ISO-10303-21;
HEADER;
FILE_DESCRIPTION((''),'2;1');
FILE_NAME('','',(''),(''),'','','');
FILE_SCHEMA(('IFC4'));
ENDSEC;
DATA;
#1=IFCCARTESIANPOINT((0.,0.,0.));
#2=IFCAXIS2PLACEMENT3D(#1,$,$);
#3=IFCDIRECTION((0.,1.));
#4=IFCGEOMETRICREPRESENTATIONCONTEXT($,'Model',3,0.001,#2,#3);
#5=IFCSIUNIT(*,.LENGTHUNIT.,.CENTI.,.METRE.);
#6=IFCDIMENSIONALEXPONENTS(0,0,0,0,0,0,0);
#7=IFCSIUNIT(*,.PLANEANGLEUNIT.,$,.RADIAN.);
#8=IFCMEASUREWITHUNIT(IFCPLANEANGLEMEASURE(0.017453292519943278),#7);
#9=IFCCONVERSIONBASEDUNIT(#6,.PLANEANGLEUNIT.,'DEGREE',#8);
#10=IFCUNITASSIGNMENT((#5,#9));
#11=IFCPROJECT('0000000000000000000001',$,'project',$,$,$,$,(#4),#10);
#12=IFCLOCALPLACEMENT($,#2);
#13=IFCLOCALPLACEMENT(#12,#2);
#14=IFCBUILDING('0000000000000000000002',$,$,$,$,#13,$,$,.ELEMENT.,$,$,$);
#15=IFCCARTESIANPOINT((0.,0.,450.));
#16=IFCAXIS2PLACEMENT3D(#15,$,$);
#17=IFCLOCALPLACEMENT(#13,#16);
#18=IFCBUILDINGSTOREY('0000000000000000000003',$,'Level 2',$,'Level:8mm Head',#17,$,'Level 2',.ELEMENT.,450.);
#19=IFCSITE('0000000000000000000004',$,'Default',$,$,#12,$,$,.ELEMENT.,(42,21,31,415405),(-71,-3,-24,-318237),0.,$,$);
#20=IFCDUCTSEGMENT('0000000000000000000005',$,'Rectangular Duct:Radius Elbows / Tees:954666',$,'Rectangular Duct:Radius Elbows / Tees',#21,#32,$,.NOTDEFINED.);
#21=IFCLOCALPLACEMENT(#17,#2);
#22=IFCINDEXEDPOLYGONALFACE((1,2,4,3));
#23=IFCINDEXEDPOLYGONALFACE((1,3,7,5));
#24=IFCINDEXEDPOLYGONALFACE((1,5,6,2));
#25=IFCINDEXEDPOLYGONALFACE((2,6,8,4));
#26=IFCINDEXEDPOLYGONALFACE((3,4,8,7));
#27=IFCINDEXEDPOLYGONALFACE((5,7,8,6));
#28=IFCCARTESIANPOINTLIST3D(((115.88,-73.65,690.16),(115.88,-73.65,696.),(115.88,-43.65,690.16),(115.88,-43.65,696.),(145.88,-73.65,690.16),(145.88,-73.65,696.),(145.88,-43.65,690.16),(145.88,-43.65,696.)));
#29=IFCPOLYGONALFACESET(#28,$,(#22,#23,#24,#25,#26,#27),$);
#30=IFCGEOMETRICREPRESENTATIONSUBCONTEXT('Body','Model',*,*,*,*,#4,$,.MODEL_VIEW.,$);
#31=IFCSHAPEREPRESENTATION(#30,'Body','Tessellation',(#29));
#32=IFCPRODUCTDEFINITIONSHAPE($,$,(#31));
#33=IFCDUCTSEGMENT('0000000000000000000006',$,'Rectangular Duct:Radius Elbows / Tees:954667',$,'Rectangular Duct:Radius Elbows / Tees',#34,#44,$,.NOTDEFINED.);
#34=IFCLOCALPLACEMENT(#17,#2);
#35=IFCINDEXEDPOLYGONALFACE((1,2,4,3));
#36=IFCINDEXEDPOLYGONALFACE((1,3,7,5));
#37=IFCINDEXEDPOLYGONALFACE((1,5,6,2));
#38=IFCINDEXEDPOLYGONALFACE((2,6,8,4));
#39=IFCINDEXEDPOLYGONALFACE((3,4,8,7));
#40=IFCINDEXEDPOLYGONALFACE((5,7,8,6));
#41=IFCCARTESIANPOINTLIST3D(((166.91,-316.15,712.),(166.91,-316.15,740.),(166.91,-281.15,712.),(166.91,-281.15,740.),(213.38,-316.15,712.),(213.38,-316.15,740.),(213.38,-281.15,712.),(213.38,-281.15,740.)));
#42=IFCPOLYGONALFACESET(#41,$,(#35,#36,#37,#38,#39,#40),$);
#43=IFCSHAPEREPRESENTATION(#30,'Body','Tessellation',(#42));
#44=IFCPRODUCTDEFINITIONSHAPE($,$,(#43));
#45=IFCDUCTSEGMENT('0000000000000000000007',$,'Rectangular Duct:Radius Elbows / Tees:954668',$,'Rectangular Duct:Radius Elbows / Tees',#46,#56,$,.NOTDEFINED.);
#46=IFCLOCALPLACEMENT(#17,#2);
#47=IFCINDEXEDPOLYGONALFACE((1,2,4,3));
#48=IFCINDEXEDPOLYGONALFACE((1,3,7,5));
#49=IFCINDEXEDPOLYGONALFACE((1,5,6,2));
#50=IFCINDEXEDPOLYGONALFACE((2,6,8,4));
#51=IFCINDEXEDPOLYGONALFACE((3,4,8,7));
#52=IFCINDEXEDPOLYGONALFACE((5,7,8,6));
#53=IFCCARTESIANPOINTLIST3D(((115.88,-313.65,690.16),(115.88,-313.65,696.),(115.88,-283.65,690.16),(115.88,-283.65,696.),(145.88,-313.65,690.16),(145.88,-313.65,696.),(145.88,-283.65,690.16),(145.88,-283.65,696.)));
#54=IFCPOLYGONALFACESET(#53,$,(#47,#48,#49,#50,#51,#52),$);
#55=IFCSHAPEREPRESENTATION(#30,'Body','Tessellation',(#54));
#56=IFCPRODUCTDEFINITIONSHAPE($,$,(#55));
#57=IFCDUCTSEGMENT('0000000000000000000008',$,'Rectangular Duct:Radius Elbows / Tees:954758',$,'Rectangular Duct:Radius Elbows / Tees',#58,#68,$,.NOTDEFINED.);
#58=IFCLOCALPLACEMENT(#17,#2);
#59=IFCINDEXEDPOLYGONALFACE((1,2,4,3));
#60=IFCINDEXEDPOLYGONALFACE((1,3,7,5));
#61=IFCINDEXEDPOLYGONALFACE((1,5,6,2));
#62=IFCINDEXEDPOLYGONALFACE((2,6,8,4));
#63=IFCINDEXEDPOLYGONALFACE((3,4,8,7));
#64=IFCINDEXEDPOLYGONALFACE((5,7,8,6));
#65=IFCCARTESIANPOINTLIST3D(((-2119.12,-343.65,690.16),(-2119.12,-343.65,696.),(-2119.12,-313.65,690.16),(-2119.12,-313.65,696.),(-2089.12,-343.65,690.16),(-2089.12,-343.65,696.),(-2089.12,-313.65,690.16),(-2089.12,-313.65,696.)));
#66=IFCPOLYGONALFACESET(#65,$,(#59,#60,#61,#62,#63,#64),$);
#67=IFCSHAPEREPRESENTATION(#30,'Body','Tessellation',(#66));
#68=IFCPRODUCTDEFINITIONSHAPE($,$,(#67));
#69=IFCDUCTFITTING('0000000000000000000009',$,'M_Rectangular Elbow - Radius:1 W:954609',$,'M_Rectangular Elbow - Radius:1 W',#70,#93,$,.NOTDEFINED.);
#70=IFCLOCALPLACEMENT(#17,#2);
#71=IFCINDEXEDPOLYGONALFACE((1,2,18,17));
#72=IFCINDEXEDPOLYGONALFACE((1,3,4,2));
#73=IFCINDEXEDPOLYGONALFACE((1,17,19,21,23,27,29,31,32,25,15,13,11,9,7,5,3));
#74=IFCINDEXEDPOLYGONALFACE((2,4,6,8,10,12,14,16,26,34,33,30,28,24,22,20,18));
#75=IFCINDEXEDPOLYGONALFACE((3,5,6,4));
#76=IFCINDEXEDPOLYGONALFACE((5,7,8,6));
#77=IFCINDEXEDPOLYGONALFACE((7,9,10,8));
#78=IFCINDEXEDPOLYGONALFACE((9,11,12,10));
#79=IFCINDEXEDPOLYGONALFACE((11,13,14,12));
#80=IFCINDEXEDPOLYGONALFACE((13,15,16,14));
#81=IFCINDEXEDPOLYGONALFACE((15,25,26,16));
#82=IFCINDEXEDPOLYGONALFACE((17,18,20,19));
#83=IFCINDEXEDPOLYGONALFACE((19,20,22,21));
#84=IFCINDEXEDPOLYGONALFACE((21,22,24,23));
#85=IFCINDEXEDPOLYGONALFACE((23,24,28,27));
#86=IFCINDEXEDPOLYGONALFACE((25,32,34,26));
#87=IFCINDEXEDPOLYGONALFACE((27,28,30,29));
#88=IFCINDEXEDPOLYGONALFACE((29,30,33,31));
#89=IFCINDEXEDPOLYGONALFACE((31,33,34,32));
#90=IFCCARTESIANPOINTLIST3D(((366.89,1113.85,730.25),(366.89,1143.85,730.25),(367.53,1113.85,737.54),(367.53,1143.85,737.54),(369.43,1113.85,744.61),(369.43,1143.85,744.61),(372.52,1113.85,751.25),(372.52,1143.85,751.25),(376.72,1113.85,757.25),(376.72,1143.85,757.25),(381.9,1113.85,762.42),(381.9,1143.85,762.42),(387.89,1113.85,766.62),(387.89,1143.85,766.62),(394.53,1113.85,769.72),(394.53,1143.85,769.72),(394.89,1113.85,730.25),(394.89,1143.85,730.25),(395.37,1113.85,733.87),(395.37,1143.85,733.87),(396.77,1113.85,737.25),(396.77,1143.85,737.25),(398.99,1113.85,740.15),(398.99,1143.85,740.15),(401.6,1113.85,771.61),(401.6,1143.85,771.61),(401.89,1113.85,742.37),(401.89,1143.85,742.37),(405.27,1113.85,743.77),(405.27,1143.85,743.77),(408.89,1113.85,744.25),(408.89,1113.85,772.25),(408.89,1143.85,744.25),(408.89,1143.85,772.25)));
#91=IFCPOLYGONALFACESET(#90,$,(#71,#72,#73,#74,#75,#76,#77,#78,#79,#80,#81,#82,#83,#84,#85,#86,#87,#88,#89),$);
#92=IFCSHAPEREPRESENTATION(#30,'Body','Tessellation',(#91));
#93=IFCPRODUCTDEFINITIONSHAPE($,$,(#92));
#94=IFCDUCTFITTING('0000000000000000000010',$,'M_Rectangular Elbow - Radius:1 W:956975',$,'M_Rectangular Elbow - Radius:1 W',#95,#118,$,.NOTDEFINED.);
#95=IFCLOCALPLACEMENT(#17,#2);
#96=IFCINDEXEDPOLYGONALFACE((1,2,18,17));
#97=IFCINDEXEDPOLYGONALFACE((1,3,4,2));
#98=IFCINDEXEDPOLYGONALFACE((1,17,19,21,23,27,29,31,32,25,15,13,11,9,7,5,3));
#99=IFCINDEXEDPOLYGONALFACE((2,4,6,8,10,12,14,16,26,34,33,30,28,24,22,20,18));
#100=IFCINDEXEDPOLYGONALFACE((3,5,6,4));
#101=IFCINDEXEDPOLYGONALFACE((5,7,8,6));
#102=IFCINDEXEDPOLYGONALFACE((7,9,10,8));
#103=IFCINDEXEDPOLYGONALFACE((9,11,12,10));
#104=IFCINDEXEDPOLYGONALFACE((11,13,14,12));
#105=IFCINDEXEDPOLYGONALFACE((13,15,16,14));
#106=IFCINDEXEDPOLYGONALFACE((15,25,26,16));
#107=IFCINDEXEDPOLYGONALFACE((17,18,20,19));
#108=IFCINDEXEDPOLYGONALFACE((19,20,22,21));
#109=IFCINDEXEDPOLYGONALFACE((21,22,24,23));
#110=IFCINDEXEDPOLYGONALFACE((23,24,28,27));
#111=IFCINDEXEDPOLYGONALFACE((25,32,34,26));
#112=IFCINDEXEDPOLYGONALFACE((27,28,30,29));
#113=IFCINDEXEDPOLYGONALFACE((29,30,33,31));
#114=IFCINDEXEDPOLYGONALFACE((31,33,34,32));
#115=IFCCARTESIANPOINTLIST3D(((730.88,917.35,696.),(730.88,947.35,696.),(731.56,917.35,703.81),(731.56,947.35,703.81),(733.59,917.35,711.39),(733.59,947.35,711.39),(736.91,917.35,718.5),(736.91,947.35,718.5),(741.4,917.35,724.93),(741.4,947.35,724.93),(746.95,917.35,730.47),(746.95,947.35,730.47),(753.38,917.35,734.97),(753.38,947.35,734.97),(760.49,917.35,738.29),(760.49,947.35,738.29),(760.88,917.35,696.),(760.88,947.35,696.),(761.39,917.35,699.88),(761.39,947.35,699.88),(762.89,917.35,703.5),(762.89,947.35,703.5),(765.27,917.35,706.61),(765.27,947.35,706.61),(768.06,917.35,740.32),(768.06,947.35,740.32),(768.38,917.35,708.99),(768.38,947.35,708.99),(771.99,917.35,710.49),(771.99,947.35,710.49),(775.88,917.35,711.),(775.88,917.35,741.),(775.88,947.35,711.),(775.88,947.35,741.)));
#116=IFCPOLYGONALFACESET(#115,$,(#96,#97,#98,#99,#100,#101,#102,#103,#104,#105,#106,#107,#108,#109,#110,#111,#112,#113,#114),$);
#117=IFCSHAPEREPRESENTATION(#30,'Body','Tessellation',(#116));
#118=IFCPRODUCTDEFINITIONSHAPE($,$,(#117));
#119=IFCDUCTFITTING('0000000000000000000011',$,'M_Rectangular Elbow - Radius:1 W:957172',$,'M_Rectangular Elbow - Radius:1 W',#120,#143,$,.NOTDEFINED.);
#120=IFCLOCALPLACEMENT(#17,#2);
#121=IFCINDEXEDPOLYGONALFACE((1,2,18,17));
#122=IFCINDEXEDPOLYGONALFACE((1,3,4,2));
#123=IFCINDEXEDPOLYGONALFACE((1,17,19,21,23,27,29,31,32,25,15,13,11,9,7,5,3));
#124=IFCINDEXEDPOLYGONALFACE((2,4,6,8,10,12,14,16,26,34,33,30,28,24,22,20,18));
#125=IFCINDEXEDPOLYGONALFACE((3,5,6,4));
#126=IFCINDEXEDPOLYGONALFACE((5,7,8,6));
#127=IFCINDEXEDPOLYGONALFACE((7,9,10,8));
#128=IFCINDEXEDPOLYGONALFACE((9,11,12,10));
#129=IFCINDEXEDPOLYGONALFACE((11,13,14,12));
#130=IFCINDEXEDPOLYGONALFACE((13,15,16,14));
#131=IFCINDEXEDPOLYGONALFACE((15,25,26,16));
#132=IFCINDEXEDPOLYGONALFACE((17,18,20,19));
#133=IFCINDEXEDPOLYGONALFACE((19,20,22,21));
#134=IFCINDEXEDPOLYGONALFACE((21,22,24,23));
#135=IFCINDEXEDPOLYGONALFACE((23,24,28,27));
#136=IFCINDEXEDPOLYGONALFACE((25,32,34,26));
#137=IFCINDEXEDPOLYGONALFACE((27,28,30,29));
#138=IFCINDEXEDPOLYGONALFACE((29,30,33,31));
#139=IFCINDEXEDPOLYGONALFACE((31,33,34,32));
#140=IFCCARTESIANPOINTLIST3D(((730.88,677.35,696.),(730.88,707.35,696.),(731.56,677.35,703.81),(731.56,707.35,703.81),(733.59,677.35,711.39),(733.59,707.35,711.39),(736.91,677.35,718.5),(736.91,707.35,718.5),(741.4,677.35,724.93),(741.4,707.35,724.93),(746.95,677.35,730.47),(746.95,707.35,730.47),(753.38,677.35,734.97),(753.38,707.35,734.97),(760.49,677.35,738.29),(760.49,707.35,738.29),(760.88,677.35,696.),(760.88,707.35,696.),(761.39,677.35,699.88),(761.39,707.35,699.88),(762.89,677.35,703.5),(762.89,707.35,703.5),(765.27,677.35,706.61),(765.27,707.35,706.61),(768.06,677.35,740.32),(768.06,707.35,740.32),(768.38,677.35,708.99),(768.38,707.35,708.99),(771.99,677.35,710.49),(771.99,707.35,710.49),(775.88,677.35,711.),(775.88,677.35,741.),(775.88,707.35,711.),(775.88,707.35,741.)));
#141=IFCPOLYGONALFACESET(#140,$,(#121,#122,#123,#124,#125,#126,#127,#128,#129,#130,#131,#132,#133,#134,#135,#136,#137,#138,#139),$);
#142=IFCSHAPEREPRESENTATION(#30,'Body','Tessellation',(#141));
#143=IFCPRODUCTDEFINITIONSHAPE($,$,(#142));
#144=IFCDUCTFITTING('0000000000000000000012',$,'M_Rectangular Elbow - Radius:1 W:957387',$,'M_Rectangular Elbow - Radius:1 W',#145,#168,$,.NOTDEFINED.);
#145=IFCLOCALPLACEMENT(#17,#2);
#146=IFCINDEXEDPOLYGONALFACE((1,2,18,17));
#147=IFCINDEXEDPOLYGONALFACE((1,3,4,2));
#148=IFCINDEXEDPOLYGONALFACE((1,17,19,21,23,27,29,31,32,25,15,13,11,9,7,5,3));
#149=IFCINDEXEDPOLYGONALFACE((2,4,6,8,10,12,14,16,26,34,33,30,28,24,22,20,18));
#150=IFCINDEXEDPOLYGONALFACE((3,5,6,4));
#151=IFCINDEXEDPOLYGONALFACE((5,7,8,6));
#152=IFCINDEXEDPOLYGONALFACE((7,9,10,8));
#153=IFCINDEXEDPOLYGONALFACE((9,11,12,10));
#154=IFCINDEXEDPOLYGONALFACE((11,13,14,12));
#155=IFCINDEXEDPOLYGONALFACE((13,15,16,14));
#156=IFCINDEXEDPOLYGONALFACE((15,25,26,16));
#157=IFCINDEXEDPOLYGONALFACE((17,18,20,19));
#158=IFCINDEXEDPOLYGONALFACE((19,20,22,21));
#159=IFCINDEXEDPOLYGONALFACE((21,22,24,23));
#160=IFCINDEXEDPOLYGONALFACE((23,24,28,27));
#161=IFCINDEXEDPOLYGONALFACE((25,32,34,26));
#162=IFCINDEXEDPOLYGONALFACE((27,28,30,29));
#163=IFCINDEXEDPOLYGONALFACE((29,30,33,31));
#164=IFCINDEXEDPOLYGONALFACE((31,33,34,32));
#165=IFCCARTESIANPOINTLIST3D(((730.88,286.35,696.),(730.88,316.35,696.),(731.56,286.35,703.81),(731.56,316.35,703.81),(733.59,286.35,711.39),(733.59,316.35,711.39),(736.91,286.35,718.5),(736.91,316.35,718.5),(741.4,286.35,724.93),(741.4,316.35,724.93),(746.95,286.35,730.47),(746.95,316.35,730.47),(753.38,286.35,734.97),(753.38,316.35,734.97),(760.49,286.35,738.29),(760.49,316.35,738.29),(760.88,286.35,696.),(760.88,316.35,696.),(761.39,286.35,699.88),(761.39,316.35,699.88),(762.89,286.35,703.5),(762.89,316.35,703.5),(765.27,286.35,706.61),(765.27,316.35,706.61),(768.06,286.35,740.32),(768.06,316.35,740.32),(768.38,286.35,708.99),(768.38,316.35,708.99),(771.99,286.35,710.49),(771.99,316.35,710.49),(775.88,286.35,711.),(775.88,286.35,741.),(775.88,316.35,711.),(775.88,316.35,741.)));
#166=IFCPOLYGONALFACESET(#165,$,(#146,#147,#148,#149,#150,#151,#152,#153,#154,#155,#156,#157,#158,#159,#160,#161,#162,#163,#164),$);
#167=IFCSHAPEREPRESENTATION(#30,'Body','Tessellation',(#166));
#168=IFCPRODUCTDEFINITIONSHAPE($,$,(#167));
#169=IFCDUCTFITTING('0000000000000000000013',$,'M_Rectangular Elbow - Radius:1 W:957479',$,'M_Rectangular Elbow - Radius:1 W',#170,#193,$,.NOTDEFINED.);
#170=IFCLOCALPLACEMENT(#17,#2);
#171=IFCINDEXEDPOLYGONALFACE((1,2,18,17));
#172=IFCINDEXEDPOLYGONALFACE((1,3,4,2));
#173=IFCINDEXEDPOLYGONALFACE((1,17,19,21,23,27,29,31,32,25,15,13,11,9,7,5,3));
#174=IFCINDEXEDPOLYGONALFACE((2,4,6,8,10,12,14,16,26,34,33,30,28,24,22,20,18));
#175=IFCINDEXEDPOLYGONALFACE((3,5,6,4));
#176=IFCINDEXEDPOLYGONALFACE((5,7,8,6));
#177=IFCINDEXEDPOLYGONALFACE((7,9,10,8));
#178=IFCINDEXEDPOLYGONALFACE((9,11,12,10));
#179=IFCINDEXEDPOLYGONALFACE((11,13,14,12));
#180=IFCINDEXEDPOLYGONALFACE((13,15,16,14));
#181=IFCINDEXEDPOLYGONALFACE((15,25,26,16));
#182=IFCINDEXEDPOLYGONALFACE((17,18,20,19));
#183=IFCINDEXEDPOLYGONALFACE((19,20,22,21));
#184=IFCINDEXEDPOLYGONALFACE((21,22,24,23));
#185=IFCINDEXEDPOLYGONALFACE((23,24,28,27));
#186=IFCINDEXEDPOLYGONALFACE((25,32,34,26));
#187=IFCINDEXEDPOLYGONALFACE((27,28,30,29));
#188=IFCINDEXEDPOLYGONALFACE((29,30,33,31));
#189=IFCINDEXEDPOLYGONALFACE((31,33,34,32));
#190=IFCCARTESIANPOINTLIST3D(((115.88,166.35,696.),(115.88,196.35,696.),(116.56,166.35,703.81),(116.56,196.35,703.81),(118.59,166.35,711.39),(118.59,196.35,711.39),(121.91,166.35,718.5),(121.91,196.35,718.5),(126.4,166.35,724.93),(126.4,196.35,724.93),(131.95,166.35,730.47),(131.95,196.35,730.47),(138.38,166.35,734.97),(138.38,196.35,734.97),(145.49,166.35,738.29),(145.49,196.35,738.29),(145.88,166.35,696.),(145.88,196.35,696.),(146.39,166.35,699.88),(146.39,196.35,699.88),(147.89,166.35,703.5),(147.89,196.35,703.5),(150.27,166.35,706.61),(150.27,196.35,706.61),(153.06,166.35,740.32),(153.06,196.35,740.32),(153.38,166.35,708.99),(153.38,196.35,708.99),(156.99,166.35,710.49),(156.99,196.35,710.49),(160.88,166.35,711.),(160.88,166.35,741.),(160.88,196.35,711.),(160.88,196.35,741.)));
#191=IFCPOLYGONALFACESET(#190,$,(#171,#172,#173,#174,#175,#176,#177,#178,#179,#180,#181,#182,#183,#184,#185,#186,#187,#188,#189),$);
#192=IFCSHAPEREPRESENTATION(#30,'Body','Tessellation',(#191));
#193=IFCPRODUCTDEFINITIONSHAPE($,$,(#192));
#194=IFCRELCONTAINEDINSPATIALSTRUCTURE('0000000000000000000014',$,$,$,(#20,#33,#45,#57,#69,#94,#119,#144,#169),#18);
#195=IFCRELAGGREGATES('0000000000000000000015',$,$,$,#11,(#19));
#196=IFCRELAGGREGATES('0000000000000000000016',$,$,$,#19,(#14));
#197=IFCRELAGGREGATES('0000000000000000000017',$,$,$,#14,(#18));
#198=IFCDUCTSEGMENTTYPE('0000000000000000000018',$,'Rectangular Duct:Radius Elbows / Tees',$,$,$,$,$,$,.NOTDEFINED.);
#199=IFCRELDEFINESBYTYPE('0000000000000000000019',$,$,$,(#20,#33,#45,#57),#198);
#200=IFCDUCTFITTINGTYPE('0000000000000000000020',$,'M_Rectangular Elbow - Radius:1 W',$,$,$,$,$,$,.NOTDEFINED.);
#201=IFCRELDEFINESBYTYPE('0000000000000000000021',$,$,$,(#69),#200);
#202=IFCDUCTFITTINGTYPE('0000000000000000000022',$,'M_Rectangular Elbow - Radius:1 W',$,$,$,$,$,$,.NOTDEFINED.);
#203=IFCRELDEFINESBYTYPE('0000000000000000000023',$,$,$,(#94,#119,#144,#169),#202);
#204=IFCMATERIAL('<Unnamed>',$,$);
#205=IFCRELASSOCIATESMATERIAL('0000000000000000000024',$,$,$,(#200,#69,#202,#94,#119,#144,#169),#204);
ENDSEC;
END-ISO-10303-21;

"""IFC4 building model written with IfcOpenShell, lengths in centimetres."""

from ifc_helpers import new_model, entity, si_unit, converted_unit, direction, frame, origin, place, context, subcontext, project, spatial, line, arc, indexed_curve, outline, extrude, source, transform, mapped, material, type_object, type_shapes, element, save


model = new_model("IFC4")

# Units and contexts
model_context = context("Model", 3, precision=0.001, world=origin(), true_north=direction((0.0, 1.0)))
body_context = subcontext(model_context, "Body", "Model", "MODEL_VIEW")
ifc_project = project(units=[si_unit("LENGTHUNIT", "METRE", prefix="CENTI"), converted_unit("PLANEANGLEUNIT", "DEGREE", entity("IfcPlaneAngleMeasure", 0.017453292519943278), si_unit("PLANEANGLEUNIT", "RADIAN"), dimensions=[0, 0, 0, 0, 0, 0, 0])], contexts=[model_context])

# Site, building, storey
site_placement = place(None, origin())
site = spatial("IfcSite", under=ifc_project, at=site_placement, Name="Default", CompositionType="ELEMENT", RefLatitude=(42, 21, 31, 415405), RefLongitude=(-71, -3, -24, -318237), RefElevation=0.0)
building_placement = place(site_placement, origin())
building = spatial("IfcBuilding", under=site, at=building_placement, CompositionType="ELEMENT")
storey_placement = place(building_placement, frame((0.0, 0.0, 450.0)))
storey = spatial("IfcBuildingStorey", under=building, at=storey_placement, Name="Level 2", ObjectType="Level:8mm Head", LongName="Level 2", CompositionType="ELEMENT", Elevation=450.0)

# Duct segments
duct_segment_type_1 = type_object("IfcDuctSegmentType", Name="Rectangular Duct:Radius Elbows / Tees", PredefinedType="NOTDEFINED")
duct_segment_1_placement = place(storey_placement, origin())
element("IfcDuctSegment", 1, at=duct_segment_1_placement, inside=storey, type_object=duct_segment_type_1, Name="Rectangular Duct:Radius Elbows / Tees:954666", ObjectType="Rectangular Duct:Radius Elbows / Tees", PredefinedType="NOTDEFINED", context=body_context, shape_type="SweptSolid", body=[
    extrude(outline(indexed_curve([(-15.0, -15.0), (15.0, -15.0), (15.0, 15.0), (-15.0, 15.0), (-15.0, -15.0)], self_intersect=False)), frame((130.88, -58.65, 690.16)), (0.0, 0.0, 1.0), 5.84),
])
duct_segment_2_placement = place(storey_placement, origin())
element("IfcDuctSegment", 2, at=duct_segment_2_placement, inside=storey, type_object=duct_segment_type_1, Name="Rectangular Duct:Radius Elbows / Tees:954667", ObjectType="Rectangular Duct:Radius Elbows / Tees", PredefinedType="NOTDEFINED", context=body_context, shape_type="SweptSolid", body=[
    extrude(outline(indexed_curve([(-23.23, -17.5), (23.23, -17.5), (23.23, 17.5), (-23.23, 17.5), (-23.23, -17.5)], self_intersect=False)), frame((190.14, -298.65, 712.0)), (0.0, 0.0, 1.0), 28.0),
])
duct_segment_3_placement = place(storey_placement, origin())
element("IfcDuctSegment", 3, at=duct_segment_3_placement, inside=storey, type_object=duct_segment_type_1, Name="Rectangular Duct:Radius Elbows / Tees:954668", ObjectType="Rectangular Duct:Radius Elbows / Tees", PredefinedType="NOTDEFINED", context=body_context, shape_type="SweptSolid", body=[
    extrude(outline(indexed_curve([(-15.0, -15.0), (15.0, -15.0), (15.0, 15.0), (-15.0, 15.0), (-15.0, -15.0)], self_intersect=False)), frame((130.88, -298.65, 690.16)), (0.0, 0.0, 1.0), 5.84),
])
duct_segment_4_placement = place(storey_placement, origin())
element("IfcDuctSegment", 4, at=duct_segment_4_placement, inside=storey, type_object=duct_segment_type_1, Name="Rectangular Duct:Radius Elbows / Tees:954758", ObjectType="Rectangular Duct:Radius Elbows / Tees", PredefinedType="NOTDEFINED", context=body_context, shape_type="SweptSolid", body=[
    extrude(outline(indexed_curve([(-15.0, -15.0), (15.0, -15.0), (15.0, 15.0), (-15.0, 15.0), (-15.0, -15.0)], self_intersect=False)), frame((-2104.12, -328.65, 690.16)), (0.0, 0.0, 1.0), 5.84),
])

# Duct fittings
ifc_material = material(Name="<Unnamed>")
duct_fitting_type_1 = type_object("IfcDuctFittingType", Name="M_Rectangular Elbow - Radius:1 W", PredefinedType="NOTDEFINED", material=ifc_material)
shared_shape_1 = source(origin(), body_context, "Body", "SweptSolid", [
    extrude(outline(indexed_curve([(-28.0, -14.0), (0.0, -14.0), (4.1, -4.1), (14.0, 0.0), (14.0, 28.0), (-15.7, 15.7)], segments=[line(1, 2), arc(2, 3, 4), line(4, 5), arc(5, 6, 1)], self_intersect=False)), frame((-14.0, 14.0, -15.0), z_axis=(0.0, 0.0, 1.0), x_axis=(-1.0, 0.0, 0.0)), (0.0, 0.0, 1.0), 30.0),
])
type_shapes(duct_fitting_type_1, [shared_shape_1])
duct_fitting_1_placement = place(storey_placement, frame((380.89, 1128.85, 758.25), z_axis=(0.0, 1.0, 0.0), x_axis=(0.0, 0.0, 1.0)))
element("IfcDuctFitting", 5, at=duct_fitting_1_placement, inside=storey, type_object=duct_fitting_type_1, material=ifc_material, Name="M_Rectangular Elbow - Radius:1 W:954609", ObjectType="M_Rectangular Elbow - Radius:1 W", PredefinedType="NOTDEFINED", context=body_context, shape_type="MappedRepresentation", body=[
    mapped(shared_shape_1, transform((0.0, 0.0, 0.0), scale=1.0)),
])
duct_fitting_type_2 = type_object("IfcDuctFittingType", Name="M_Rectangular Elbow - Radius:1 W", PredefinedType="NOTDEFINED", material=ifc_material)
shared_shape_2 = source(origin(), body_context, "Body", "SweptSolid", [
    extrude(outline(indexed_curve([(-30.0, -15.0), (0.0, -15.0), (4.39, -4.39), (15.0, 0.0), (15.0, 30.0), (-16.82, 16.82)], segments=[line(1, 2), arc(2, 3, 4), line(4, 5), arc(5, 6, 1)], self_intersect=False)), frame((-15.0, 15.0, -15.0), z_axis=(0.0, 0.0, 1.0), x_axis=(-1.0, 0.0, 0.0)), (0.0, 0.0, 1.0), 30.0),
])
type_shapes(duct_fitting_type_2, [shared_shape_2])
for number, where, z_axis, x_axis, name in (
    (6, (745.88, 932.35, 726.0), (0.0, -1.0, 0.0), (-1.0, 0.0, 0.0), "M_Rectangular Elbow - Radius:1 W:956975"),
    (7, (745.88, 692.35, 726.0), (0.0, -1.0, 0.0), (-1.0, 0.0, 0.0), "M_Rectangular Elbow - Radius:1 W:957172"),
    (8, (745.88, 301.35, 726.0), (0.0, -1.0, 0.0), (-1.0, 0.0, 0.0), "M_Rectangular Elbow - Radius:1 W:957387"),
    (9, (130.88, 181.35, 726.0), (0.0, -1.0, 0.0), (-1.0, 0.0, 0.0), "M_Rectangular Elbow - Radius:1 W:957479"),
):
    element("IfcDuctFitting", number, at=place(storey_placement, frame(where, z_axis=z_axis, x_axis=x_axis)), inside=storey, type_object=duct_fitting_type_2, material=ifc_material, Name=name, ObjectType="M_Rectangular Elbow - Radius:1 W", PredefinedType="NOTDEFINED", context=body_context, shape_type="MappedRepresentation", body=[
        mapped(shared_shape_2, transform((0.0, 0.0, 0.0), scale=1.0)),
    ])

save(model, "model.ifc")
